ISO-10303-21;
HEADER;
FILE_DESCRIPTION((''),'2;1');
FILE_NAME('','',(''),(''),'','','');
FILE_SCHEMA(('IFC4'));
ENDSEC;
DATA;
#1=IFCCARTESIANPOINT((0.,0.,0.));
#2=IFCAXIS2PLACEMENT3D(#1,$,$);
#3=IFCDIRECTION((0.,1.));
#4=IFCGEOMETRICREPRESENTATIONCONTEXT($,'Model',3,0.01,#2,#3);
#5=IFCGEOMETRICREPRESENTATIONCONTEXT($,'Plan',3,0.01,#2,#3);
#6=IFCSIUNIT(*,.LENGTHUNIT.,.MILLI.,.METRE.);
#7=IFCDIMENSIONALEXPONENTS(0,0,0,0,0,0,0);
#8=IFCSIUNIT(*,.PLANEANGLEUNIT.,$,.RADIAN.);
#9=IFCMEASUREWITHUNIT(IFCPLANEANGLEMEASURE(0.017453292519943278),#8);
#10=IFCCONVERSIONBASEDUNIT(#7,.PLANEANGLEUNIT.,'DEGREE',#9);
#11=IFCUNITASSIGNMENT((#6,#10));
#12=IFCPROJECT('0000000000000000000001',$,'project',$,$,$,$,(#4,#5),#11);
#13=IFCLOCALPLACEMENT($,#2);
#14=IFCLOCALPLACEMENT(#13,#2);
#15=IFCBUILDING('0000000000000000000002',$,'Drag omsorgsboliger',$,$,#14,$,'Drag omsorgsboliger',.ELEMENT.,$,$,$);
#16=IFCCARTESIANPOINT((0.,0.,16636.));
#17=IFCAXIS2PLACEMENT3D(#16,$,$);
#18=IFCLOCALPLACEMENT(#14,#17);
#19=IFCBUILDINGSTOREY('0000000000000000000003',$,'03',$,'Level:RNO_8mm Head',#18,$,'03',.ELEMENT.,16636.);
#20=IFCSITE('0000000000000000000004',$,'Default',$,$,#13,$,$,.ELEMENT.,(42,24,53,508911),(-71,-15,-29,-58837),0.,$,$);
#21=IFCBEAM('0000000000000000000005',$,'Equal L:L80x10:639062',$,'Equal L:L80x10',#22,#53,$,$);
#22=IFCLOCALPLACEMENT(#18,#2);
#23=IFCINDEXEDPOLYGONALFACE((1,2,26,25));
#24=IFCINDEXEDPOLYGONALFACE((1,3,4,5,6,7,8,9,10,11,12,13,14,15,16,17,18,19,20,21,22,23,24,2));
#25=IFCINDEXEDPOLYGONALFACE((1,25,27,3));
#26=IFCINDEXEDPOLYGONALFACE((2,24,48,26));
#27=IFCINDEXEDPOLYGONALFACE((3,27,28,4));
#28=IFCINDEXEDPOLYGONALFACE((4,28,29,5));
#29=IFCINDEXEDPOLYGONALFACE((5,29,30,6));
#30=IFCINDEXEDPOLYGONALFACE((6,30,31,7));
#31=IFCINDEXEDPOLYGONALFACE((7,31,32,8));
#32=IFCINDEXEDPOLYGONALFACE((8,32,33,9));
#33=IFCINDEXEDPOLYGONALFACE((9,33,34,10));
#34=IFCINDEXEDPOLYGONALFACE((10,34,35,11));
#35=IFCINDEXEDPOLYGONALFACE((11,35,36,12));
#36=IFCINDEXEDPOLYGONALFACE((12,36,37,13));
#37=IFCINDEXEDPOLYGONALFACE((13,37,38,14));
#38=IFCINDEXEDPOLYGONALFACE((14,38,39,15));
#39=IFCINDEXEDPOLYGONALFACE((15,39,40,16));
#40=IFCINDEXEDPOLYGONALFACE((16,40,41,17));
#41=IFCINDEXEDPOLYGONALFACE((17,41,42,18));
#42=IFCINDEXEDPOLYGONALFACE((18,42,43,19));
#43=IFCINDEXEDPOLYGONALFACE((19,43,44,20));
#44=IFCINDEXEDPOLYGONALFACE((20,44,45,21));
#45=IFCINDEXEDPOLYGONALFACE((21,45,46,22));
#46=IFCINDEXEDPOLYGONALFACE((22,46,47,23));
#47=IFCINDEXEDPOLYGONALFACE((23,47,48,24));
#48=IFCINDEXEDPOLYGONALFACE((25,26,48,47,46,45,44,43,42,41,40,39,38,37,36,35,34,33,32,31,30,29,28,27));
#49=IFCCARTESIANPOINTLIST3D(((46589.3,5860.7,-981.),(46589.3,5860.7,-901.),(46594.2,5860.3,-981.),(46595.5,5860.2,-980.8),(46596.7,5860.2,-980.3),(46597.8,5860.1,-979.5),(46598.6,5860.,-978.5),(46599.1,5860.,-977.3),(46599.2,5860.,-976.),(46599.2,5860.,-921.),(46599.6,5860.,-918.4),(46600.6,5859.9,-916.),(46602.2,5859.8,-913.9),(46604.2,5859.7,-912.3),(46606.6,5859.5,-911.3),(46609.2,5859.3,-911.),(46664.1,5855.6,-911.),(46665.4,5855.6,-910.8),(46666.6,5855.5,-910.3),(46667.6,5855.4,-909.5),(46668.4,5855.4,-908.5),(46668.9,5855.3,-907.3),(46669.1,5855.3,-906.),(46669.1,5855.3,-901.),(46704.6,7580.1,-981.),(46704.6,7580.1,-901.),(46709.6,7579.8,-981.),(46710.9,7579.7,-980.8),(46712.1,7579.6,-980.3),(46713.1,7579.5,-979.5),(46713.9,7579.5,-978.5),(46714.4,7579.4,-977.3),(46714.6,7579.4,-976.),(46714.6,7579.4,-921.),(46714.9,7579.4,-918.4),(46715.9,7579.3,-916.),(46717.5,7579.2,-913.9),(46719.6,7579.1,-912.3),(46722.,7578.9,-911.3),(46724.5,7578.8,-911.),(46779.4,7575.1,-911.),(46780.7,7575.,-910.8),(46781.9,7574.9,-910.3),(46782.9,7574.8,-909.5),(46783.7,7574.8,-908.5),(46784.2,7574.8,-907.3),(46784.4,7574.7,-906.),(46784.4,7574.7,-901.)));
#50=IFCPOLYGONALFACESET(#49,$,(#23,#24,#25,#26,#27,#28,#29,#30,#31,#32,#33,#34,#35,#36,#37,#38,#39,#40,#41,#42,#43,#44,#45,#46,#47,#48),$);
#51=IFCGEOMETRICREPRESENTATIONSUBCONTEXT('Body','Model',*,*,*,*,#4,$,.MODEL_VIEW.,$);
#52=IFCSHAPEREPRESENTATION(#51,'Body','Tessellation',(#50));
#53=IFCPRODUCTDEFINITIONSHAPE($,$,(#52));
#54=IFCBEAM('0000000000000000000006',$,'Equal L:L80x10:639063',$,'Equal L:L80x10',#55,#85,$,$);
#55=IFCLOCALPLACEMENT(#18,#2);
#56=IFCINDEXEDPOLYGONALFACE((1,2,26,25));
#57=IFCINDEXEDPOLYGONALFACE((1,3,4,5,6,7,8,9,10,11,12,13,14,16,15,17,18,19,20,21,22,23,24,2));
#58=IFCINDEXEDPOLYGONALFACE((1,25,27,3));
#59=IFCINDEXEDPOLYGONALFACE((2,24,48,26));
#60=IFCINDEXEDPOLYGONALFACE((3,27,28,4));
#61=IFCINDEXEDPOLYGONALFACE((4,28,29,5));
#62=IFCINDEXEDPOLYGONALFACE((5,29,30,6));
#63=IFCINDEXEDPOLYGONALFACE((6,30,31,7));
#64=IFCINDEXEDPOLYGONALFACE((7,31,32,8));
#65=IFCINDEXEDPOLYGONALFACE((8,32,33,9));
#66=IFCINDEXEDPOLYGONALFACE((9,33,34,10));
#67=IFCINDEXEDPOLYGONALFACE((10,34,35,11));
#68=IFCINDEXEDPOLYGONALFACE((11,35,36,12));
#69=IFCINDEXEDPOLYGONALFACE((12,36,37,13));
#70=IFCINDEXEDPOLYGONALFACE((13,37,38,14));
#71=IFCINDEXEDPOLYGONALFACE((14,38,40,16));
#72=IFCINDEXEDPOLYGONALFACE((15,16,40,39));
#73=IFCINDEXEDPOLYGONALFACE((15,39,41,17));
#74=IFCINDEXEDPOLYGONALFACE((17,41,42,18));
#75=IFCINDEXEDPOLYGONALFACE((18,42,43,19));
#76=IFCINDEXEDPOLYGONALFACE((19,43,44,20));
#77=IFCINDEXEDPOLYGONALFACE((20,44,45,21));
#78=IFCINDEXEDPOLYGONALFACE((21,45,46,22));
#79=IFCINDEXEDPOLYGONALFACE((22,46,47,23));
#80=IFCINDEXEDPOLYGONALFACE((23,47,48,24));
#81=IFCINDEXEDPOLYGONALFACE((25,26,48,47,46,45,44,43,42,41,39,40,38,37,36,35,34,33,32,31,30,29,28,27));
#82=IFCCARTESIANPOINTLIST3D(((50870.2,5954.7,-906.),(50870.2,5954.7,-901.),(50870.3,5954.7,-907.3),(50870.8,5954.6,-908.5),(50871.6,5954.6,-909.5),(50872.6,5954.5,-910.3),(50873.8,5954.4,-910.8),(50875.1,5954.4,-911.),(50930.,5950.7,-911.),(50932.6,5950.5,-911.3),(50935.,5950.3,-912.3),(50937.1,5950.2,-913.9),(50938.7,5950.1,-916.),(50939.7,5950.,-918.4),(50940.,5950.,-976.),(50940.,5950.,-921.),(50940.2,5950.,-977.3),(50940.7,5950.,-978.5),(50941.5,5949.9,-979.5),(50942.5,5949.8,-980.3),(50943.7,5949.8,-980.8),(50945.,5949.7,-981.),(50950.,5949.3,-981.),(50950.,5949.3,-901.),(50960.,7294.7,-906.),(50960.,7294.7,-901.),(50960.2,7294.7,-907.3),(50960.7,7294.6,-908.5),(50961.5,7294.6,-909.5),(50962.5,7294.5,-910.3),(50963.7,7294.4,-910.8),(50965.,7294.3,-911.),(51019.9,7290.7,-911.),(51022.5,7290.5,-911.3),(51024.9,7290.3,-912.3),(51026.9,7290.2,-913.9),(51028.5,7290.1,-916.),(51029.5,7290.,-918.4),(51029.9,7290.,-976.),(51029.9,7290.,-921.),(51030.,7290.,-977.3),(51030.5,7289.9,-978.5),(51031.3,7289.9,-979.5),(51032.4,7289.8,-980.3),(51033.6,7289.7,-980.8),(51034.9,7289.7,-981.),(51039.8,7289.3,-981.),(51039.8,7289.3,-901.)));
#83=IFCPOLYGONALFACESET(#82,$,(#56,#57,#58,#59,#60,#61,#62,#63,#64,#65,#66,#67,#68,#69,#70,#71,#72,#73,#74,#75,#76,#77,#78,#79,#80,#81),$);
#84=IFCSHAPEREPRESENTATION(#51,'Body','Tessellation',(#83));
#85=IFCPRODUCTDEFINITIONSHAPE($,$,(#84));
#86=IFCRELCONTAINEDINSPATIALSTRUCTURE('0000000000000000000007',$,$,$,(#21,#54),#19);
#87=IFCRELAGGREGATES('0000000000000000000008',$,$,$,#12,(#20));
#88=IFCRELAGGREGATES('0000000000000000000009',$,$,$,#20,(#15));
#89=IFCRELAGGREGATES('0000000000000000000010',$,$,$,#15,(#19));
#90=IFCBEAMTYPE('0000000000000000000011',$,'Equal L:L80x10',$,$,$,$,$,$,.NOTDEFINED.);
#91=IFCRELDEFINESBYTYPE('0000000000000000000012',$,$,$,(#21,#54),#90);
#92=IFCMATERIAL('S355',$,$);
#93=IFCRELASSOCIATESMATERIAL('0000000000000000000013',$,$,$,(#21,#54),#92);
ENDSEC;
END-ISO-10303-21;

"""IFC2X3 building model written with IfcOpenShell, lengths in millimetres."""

from ifc_helpers import new_model, entity, si_unit, converted_unit, direction, frame, frame_2d, origin, place, context, subcontext, project, spatial, polyline, circle_curve, parameter, trimmed, segment, composite_curve, outline, extrude, material, type_object, element, save


model = new_model("IFC2X3")

# Units and contexts
model_context = context("Model", 3, precision=0.01, world=origin(), true_north=direction((0.0, 1.0)))
plan_context = context("Plan", 3, precision=0.01, world=origin(), true_north=direction((0.0, 1.0)))
body_context = subcontext(model_context, "Body", "Model", "MODEL_VIEW")
ifc_project = project(units=[si_unit("LENGTHUNIT", "METRE", prefix="MILLI"), converted_unit("PLANEANGLEUNIT", "DEGREE", entity("IfcPlaneAngleMeasure", 0.017453292519943278), si_unit("PLANEANGLEUNIT", "RADIAN"), dimensions=[0, 0, 0, 0, 0, 0, 0])], contexts=[model_context, plan_context])

# Site, building, storey
site_placement = place(None, origin())
site = spatial("IfcSite", under=ifc_project, at=site_placement, Name="Default", CompositionType="ELEMENT", RefLatitude=(42, 24, 53, 508911), RefLongitude=(-71, -15, -29, -58837), RefElevation=0.0)
building_placement = place(site_placement, origin())
building = spatial("IfcBuilding", under=site, at=building_placement, Name="Drag omsorgsboliger", LongName="Drag omsorgsboliger", CompositionType="ELEMENT")
storey_placement = place(building_placement, frame((0.0, 0.0, 16636.0)))
storey = spatial("IfcBuildingStorey", under=building, at=storey_placement, Name="03", ObjectType="Level:RNO_8mm Head", LongName="03", CompositionType="ELEMENT", Elevation=16636.0)

# Beams
ifc_material = material(Name="S355")
beam_type_1 = type_object("IfcBeamType", Name="Equal L:L80x10", PredefinedType="NOTDEFINED")
beam_1_placement = place(storey_placement, frame((46723.3, 7508.7, -981.0), z_axis=(0.0, 0.0, 1.0), x_axis=(-0.066923, -0.997758, 0.0)))
element("IfcBeam", 1, at=beam_1_placement, inside=storey, type_object=beam_type_1, material=ifc_material, Name="Equal L:L80x10:639062", ObjectType="Equal L:L80x10", context=body_context, shape_type="SweptSolid", body=[
    extrude(outline(composite_curve([segment(polyline([(-31.1, -31.1), (48.9, -31.1)]), True, "CONTINUOUS"), segment(polyline([(48.9, -31.1), (48.9, -26.1)]), True, "CONTINUOUS"), segment(trimmed(circle_curve(frame_2d((43.9, -26.1), x_axis=(1.0, 0.0)), 5.0), [parameter(0.0)], [parameter(90.0)], True, "PARAMETER"), True, "CONTINUOUS"), segment(polyline([(43.9, -21.1), (-11.1, -21.1)]), True, "CONTINUOUS"), segment(trimmed(circle_curve(frame_2d((-11.1, -11.1), x_axis=(0.0, -1.0)), 10.0), [parameter(270.0)], [parameter(0.0)], True, "PARAMETER"), False, "CONTINUOUS"), segment(polyline([(-21.1, -11.1), (-21.1, 43.9)]), True, "CONTINUOUS"), segment(trimmed(circle_curve(frame_2d((-26.1, 43.9), x_axis=(1.0, 0.0)), 5.0), [parameter(0.0)], [parameter(90.0)], True, "PARAMETER"), True, "CONTINUOUS"), segment(polyline([(-26.1, 48.9), (-31.1, 48.9)]), True, "CONTINUOUS"), segment(polyline([(-31.1, 48.9), (-31.1, -31.1)]), True, "CONTINUOUS")], self_intersect=False)), frame((-70.0, 7.7, 48.9), z_axis=(1.0, 0.0, 0.0), x_axis=(0.0, 0.0, -1.0)), (0.0, 0.0, 1.0), 1723.3),
])
beam_2_placement = place(storey_placement, frame((51017.2, 7300.9, -981.0), z_axis=(0.0, 0.0, 1.0), x_axis=(-0.066923, -0.997758, 0.0)))
element("IfcBeam", 2, at=beam_2_placement, inside=storey, type_object=beam_type_1, material=ifc_material, Name="Equal L:L80x10:639063", ObjectType="Equal L:L80x10", context=body_context, shape_type="SweptSolid", body=[
    extrude(outline(composite_curve([segment(polyline([(-31.1, -48.9), (-26.1, -48.9)]), True, "CONTINUOUS"), segment(trimmed(circle_curve(frame_2d((-26.1, -43.9), x_axis=(0.0, -1.0)), 5.0), [parameter(0.0)], [parameter(90.0)], True, "PARAMETER"), True, "CONTINUOUS"), segment(polyline([(-21.1, -43.9), (-21.1, 11.1)]), True, "CONTINUOUS"), segment(trimmed(circle_curve(frame_2d((-11.1, 11.1), x_axis=(-1.0, 0.0)), 10.0), [parameter(270.0)], [parameter(0.0)], True, "PARAMETER"), False, "CONTINUOUS"), segment(polyline([(-11.1, 21.1), (43.9, 21.1)]), True, "CONTINUOUS"), segment(trimmed(circle_curve(frame_2d((43.9, 26.1), x_axis=(0.0, -1.0)), 5.0), [parameter(0.0)], [parameter(90.0)], True, "PARAMETER"), True, "CONTINUOUS"), segment(polyline([(48.9, 26.1), (48.9, 31.1)]), True, "CONTINUOUS"), segment(polyline([(48.9, 31.1), (-31.1, 31.1)]), True, "CONTINUOUS"), segment(polyline([(-31.1, 31.1), (-31.1, -48.9)]), True, "CONTINUOUS")], self_intersect=False)), frame((10.0, -7.7, 48.9), z_axis=(1.0, 0.0, 0.0), x_axis=(0.0, 0.0, -1.0)), (0.0, 0.0, 1.0), 1343.0),
])

save(model, "model.ifc")
